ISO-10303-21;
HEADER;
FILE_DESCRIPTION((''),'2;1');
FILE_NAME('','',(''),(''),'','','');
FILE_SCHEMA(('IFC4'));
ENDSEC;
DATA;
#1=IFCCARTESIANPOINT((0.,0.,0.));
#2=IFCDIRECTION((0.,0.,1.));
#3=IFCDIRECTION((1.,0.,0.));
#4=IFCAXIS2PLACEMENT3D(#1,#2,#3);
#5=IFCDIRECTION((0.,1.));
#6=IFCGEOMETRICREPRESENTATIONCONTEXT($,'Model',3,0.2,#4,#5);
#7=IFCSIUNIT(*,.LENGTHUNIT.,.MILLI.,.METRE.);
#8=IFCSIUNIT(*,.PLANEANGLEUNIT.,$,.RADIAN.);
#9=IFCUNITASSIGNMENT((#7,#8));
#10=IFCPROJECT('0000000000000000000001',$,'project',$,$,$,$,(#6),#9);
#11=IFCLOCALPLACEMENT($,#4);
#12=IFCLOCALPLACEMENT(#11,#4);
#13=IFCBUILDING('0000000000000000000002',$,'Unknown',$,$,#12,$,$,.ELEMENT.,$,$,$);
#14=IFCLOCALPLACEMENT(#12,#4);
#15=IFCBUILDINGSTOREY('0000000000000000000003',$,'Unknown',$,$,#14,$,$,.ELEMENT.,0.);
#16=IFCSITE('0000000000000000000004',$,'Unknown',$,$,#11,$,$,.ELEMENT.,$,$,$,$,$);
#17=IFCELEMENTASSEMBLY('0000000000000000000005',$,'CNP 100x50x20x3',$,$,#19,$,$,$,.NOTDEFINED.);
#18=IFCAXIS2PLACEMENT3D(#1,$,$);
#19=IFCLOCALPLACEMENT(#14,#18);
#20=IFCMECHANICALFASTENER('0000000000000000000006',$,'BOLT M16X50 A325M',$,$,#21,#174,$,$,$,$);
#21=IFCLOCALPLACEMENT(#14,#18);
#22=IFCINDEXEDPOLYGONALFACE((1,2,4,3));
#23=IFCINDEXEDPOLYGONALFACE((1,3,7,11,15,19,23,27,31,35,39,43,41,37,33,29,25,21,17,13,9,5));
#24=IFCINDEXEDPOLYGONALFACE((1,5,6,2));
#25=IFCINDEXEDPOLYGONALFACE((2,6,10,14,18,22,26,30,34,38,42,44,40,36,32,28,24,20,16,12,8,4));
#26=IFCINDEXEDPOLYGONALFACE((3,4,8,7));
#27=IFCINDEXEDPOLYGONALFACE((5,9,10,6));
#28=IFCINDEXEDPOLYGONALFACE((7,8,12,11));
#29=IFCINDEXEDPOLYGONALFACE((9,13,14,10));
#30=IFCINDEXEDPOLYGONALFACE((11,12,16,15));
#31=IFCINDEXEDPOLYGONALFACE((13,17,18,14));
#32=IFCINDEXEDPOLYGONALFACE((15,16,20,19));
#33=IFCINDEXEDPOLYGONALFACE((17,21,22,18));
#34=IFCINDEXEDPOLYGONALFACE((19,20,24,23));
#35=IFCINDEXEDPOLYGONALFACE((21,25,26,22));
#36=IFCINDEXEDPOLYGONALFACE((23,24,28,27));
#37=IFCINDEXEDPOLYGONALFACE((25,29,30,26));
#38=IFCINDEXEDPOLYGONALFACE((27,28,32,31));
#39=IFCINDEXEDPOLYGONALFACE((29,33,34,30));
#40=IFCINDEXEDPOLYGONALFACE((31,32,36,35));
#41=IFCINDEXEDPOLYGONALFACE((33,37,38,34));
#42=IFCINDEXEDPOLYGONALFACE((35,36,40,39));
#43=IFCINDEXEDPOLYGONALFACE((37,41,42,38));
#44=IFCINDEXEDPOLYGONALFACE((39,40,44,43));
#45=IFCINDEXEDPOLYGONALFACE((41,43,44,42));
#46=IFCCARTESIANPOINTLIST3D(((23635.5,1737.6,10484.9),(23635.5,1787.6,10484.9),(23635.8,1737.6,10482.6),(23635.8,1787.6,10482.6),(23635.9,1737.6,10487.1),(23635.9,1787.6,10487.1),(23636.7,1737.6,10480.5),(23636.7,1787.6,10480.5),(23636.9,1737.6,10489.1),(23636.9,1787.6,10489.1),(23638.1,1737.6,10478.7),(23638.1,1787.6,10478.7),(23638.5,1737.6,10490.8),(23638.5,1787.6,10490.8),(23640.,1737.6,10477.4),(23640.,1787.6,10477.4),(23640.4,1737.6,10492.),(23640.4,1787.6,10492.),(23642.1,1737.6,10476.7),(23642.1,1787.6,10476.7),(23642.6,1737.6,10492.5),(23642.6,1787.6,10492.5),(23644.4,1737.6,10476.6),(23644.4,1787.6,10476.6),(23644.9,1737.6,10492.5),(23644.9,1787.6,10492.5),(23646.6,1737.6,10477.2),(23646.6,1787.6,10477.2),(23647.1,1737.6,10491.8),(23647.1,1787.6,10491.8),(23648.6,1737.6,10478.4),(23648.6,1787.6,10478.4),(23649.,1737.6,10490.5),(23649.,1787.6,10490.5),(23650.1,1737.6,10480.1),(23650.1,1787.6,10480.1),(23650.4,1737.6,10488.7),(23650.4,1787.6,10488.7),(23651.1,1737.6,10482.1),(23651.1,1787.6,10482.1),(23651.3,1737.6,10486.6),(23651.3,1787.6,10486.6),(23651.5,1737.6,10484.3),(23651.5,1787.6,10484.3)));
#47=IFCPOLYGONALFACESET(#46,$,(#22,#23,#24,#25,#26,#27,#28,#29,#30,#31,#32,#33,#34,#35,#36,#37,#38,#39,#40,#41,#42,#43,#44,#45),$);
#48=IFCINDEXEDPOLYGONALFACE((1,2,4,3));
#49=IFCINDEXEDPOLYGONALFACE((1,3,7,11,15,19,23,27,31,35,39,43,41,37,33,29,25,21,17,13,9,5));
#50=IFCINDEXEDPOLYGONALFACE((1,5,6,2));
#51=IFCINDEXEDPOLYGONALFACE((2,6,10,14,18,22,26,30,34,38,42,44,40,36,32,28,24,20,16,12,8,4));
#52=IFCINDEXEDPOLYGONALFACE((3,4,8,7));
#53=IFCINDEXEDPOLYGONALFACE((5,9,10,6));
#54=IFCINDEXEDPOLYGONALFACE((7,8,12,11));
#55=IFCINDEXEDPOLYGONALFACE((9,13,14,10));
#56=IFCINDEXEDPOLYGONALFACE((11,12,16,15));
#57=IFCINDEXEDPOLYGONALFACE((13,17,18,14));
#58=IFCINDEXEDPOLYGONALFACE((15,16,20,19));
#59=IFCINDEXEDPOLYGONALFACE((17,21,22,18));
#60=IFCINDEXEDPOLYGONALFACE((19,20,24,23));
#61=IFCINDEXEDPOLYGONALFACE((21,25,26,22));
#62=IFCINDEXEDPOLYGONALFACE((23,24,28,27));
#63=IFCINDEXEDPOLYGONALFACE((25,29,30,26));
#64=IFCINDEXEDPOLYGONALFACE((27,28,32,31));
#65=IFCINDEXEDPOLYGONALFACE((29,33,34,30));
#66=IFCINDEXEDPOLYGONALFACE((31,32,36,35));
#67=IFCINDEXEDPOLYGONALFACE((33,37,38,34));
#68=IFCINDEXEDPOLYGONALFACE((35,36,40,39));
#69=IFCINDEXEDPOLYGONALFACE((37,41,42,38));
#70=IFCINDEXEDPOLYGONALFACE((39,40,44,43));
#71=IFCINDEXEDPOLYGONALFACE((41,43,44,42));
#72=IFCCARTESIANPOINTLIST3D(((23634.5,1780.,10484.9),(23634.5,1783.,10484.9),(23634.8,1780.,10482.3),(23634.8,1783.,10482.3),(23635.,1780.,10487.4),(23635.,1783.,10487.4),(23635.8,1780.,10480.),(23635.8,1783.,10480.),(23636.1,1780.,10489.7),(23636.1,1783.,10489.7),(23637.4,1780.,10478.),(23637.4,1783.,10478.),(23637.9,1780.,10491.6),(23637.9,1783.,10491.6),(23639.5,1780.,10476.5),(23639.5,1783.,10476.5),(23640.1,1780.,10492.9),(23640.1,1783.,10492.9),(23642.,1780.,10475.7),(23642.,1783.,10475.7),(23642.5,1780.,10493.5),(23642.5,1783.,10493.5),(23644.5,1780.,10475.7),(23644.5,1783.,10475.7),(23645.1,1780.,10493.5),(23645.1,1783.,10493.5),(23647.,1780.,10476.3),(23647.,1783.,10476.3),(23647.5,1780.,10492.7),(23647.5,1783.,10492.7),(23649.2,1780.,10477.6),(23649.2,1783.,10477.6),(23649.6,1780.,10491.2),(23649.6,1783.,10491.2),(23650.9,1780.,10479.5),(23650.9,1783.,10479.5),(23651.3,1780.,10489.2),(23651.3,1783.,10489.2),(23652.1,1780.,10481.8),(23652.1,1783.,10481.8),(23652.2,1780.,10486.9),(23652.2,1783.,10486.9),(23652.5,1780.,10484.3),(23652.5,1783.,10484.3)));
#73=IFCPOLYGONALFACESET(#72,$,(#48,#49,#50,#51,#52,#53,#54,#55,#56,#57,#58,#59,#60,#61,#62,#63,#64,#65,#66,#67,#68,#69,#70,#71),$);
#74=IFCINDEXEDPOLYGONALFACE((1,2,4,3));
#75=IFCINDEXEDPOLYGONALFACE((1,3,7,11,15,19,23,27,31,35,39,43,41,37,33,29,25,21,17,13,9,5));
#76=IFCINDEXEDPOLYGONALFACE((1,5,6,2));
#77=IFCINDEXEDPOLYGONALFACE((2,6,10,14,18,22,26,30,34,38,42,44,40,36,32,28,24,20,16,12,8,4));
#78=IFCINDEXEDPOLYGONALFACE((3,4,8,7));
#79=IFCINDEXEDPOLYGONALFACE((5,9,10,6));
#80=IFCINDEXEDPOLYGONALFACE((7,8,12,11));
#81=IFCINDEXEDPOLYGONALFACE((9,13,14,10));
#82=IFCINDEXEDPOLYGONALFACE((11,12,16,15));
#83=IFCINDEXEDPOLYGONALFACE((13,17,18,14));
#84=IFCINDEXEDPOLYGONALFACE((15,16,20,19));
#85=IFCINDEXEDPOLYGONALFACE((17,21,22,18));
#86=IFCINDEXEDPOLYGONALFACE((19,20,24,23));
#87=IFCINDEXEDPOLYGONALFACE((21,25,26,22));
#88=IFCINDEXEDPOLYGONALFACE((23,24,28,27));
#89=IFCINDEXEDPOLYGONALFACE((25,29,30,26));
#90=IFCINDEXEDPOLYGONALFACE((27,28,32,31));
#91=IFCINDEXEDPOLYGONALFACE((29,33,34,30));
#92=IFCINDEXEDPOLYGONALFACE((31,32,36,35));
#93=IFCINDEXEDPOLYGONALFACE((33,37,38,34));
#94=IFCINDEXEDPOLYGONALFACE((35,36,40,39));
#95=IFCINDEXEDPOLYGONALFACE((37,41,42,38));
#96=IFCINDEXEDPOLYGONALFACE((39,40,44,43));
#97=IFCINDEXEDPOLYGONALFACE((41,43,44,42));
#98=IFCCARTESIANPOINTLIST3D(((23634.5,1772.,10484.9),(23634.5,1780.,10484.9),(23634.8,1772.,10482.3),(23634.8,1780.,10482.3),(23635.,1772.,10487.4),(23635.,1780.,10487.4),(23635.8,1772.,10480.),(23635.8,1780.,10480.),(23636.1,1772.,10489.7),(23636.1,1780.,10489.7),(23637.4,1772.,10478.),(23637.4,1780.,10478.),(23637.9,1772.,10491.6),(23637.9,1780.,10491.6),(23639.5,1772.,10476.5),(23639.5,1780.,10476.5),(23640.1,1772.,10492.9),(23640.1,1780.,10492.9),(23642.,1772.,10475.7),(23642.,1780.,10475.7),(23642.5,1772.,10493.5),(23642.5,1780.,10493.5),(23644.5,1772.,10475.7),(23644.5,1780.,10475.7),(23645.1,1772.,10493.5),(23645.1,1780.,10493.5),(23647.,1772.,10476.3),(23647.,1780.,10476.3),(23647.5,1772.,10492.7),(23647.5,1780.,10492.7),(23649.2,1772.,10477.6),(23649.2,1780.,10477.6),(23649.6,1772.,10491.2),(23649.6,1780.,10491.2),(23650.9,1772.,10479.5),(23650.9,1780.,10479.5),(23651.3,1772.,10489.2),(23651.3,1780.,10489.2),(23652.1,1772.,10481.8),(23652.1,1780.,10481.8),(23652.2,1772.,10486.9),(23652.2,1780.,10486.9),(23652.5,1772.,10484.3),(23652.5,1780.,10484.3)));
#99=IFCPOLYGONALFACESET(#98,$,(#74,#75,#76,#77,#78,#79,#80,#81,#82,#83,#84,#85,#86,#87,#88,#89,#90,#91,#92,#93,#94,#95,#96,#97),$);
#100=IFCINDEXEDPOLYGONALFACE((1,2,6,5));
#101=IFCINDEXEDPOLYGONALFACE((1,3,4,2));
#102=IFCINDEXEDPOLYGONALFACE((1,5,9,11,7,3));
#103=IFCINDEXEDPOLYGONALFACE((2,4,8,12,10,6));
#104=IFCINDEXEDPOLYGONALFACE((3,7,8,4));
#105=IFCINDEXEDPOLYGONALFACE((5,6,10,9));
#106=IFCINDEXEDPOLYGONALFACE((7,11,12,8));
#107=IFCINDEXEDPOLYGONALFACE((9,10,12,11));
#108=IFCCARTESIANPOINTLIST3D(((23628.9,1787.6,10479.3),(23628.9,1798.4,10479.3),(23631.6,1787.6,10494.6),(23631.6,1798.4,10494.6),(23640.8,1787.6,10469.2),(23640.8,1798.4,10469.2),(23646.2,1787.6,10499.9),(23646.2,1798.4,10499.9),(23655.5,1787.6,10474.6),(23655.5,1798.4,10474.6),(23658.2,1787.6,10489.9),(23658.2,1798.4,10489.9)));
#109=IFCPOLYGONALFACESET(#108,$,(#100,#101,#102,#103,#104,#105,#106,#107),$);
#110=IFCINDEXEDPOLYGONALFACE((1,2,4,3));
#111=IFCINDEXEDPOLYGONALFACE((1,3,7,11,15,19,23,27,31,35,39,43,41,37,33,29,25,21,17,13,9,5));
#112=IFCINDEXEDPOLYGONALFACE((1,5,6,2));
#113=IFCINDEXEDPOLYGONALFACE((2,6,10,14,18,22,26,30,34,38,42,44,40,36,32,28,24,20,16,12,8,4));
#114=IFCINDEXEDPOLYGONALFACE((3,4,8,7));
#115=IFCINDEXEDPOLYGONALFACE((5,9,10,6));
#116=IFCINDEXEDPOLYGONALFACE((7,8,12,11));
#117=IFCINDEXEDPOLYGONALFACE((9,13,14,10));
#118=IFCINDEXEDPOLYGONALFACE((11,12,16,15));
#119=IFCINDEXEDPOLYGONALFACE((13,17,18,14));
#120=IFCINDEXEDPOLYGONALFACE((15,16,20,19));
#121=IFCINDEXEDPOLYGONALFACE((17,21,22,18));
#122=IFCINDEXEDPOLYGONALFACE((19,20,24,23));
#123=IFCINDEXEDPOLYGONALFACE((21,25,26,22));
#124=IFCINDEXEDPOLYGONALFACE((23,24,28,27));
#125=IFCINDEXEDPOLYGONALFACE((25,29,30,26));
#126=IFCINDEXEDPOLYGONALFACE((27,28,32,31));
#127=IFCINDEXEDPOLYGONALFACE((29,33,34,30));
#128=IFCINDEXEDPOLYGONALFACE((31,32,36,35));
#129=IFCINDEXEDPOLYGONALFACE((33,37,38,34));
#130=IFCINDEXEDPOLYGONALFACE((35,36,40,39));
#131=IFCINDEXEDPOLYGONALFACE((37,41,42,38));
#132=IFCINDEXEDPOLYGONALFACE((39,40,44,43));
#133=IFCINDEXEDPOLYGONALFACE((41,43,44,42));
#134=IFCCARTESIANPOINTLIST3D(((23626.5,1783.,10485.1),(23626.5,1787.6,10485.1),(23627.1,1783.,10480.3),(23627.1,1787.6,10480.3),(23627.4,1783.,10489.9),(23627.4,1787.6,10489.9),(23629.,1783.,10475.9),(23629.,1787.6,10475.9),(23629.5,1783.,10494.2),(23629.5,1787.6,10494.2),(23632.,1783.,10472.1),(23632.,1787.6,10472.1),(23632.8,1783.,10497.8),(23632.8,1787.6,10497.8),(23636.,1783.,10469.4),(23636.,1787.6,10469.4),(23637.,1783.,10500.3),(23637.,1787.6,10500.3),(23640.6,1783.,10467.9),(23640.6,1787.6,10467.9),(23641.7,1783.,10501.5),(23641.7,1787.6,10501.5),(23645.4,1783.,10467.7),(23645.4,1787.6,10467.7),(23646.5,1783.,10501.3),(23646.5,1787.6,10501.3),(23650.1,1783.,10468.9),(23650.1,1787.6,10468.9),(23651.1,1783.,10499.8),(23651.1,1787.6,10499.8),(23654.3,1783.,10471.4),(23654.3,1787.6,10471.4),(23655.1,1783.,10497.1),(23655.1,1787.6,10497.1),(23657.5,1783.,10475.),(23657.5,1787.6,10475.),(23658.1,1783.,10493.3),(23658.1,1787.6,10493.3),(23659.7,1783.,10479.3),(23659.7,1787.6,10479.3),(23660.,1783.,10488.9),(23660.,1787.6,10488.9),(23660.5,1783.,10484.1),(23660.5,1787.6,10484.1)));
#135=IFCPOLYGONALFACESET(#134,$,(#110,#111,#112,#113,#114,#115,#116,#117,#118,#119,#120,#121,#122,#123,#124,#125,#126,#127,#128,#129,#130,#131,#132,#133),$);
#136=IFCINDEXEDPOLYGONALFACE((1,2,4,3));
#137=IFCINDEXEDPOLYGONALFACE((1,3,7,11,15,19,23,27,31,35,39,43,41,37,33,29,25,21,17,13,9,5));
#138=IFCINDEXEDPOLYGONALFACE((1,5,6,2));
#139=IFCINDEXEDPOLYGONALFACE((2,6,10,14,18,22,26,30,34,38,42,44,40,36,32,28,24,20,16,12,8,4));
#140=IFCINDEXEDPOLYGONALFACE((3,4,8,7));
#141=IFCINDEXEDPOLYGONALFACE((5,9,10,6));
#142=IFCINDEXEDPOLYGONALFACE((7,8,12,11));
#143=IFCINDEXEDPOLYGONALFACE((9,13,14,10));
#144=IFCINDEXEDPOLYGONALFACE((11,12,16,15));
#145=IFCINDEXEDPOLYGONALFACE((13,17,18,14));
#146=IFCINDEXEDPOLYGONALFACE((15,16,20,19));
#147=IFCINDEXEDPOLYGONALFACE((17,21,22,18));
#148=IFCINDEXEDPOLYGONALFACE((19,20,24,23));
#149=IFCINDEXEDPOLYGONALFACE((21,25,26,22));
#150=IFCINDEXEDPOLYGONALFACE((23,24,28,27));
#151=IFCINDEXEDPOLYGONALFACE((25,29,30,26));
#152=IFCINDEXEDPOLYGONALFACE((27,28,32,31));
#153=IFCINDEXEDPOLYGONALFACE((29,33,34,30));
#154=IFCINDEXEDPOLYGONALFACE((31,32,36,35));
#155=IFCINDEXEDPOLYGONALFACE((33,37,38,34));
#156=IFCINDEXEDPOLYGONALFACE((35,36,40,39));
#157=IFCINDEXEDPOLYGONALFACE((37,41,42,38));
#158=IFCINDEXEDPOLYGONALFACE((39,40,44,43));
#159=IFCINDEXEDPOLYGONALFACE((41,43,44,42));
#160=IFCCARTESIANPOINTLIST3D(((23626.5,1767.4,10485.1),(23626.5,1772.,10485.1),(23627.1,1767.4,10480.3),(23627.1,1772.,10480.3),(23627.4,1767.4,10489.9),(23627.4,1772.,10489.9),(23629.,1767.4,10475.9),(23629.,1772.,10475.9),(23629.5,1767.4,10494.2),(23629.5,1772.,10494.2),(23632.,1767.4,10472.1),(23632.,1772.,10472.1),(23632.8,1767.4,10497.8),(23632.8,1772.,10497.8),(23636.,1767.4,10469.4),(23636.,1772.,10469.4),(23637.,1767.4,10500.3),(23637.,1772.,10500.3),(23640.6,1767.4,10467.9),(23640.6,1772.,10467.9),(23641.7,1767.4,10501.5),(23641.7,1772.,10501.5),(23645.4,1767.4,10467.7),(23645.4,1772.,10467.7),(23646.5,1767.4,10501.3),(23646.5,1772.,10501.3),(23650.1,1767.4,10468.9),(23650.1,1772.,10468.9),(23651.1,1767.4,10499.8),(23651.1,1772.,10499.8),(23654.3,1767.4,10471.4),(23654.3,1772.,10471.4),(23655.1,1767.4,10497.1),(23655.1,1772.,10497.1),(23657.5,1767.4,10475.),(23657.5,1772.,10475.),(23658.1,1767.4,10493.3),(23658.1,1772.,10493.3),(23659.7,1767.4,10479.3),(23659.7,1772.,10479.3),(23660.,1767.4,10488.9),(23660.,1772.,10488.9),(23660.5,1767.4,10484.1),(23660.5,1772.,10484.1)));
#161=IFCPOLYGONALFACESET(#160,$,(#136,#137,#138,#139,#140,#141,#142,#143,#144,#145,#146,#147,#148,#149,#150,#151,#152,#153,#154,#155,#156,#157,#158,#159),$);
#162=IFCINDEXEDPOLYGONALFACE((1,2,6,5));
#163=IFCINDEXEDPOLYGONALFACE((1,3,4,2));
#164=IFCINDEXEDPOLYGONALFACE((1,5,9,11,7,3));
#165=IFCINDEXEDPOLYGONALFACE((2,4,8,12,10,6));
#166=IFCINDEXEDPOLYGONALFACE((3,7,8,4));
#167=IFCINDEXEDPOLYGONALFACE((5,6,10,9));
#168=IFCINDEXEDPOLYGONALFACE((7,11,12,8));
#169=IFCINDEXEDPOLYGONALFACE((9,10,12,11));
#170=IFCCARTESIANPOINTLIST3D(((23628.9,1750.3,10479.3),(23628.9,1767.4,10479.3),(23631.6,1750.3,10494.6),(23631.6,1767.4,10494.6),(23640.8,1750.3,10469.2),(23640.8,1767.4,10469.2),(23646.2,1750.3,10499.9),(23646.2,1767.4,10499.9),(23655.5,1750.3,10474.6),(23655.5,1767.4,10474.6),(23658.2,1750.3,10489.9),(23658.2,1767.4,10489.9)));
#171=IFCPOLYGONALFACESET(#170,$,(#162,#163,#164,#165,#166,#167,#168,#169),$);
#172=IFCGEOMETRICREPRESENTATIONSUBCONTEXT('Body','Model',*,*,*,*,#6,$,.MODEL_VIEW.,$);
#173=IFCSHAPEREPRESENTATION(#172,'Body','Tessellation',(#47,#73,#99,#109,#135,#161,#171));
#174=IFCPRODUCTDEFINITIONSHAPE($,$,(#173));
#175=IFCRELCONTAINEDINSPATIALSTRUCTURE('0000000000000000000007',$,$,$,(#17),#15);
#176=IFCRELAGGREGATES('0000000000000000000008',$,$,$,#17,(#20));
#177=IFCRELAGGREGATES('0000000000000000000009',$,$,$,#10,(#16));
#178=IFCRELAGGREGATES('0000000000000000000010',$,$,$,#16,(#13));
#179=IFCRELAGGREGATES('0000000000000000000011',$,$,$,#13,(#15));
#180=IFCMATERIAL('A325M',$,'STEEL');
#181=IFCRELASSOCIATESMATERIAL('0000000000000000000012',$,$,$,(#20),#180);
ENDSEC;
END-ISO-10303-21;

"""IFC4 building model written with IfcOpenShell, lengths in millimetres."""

from ifc_helpers import new_model, si_unit, direction, frame, origin_with_axes, place, context, subcontext, project, spatial, line, arc, indexed_curve, outline, extrude, source, transform, mapped, material, element, aggregate, save


model = new_model("IFC4")

# Units and contexts
model_context = context("Model", 3, precision=0.2, world=origin_with_axes(), true_north=direction((0.0, 1.0)))
body_context = subcontext(model_context, "Body", "Model", "MODEL_VIEW")
ifc_project = project(units=[si_unit("LENGTHUNIT", "METRE", prefix="MILLI"), si_unit("PLANEANGLEUNIT", "RADIAN")], contexts=[model_context])

# Site, building, storey
site_placement = place(None, origin_with_axes())
site = spatial("IfcSite", under=ifc_project, at=site_placement, Name="Unknown", CompositionType="ELEMENT")
building_placement = place(site_placement, origin_with_axes())
building = spatial("IfcBuilding", under=site, at=building_placement, Name="Unknown", CompositionType="ELEMENT")
storey_placement = place(building_placement, origin_with_axes())
storey = spatial("IfcBuildingStorey", under=building, at=storey_placement, Name="Unknown", CompositionType="ELEMENT", Elevation=0.0)

# Shared definitions
ifc_material_1 = material(Name="A325M", Category="STEEL")
shared_shape = source(origin_with_axes(), body_context, "Body", "SweptSolid", [
    extrude(outline(indexed_curve([(8.0, 0.0), (0.0, 8.0), (-8.0, 0.0), (0.0, -8.0)], segments=[arc(1, 2, 3), arc(3, 4, 1)])), frame((0.0, 0.0, 15.6), z_axis=(0.0, 0.0, -1.0), x_axis=(0.0, 1.0, 0.0)), (0.0, 0.0, 1.0), 50.0),
    extrude(outline(indexed_curve([(9.0, 0.0), (0.0, 9.0), (-9.0, 0.0), (0.0, -9.0)], segments=[arc(1, 2, 3), arc(3, 4, 1)])), frame((0.0, 0.0, 11.0), z_axis=(0.0, 0.0, -1.0), x_axis=(0.0, 1.0, 0.0)), (0.0, 0.0, 1.0), 3.0),
    extrude(outline(indexed_curve([(9.0, 0.0), (0.0, 9.0), (-9.0, 0.0), (0.0, -9.0)], segments=[arc(1, 2, 3), arc(3, 4, 1)])), frame((0.0, 0.0, 8.0), z_axis=(0.0, 0.0, -1.0), x_axis=(0.0, 1.0, 0.0)), (0.0, 0.0, 1.0), 8.0),
    extrude(outline(indexed_curve([(15.6, 0.0), (7.8, 13.5), (-7.8, 13.5), (-15.6, 0.0), (-7.8, -13.5), (7.8, -13.5)], segments=[line(1, 2, 3, 4, 5, 6, 1)])), frame((0.0, 0.0, 26.4), z_axis=(0.0, 0.0, -1.0), x_axis=(0.0, 1.0, 0.0)), (0.0, 0.0, 1.0), 10.8),
    extrude(outline(indexed_curve([(17.0, 0.0), (0.0, 17.0), (-17.0, 0.0), (0.0, -17.0)], segments=[arc(1, 2, 3), arc(3, 4, 1)])), frame((0.0, 0.0, 15.6), z_axis=(0.0, 0.0, -1.0), x_axis=(0.0, 1.0, 0.0)), (0.0, 0.0, 1.0), 4.6),
    extrude(outline(indexed_curve([(17.0, 0.0), (0.0, 17.0), (-17.0, 0.0), (0.0, -17.0)], segments=[arc(1, 2, 3), arc(3, 4, 1)])), frame((0.0, 0.0, 0.0), z_axis=(0.0, 0.0, -1.0), x_axis=(0.0, 1.0, 0.0)), (0.0, 0.0, 1.0), 4.6),
    extrude(outline(indexed_curve([(15.6, 0.0), (7.8, 13.5), (-7.8, 13.5), (-15.6, 0.0), (-7.8, -13.5), (7.8, -13.5)], segments=[line(1, 2, 3, 4, 5, 6, 1)])), frame((0.0, 0.0, -4.6), z_axis=(0.0, 0.0, -1.0), x_axis=(0.0, 1.0, 0.0)), (0.0, 0.0, 1.0), 17.1),
])

# Element assembly, mechanical fastener
assembly_1_placement = place(storey_placement, frame((25552.5, 1805.0, 10153.1), z_axis=(0.173648, 0.0, 0.984808), x_axis=(-0.984808, 0.0, 0.173648)))
assembly_1 = element("IfcElementAssembly", 1, at=assembly_1_placement, inside=storey, Name="CNP 100x50x20x3", PredefinedType="NOTDEFINED")
mechanical_fastener_1_placement = place(assembly_1_placement, frame((1937.5, 33.0, -5.0), z_axis=(0.0, -1.0, 0.0), x_axis=(-1.0, 0.0, 0.0)))
mechanical_fastener_1 = element("IfcMechanicalFastener", 2, at=mechanical_fastener_1_placement, material=ifc_material_1, Name="BOLT M16X50 A325M", context=body_context, shape_type="MappedRepresentation", body=[
    mapped(shared_shape, transform((0.0, 0.0, 0.0))),
])
aggregate(assembly_1, [mechanical_fastener_1])

save(model, "model.ifc")
